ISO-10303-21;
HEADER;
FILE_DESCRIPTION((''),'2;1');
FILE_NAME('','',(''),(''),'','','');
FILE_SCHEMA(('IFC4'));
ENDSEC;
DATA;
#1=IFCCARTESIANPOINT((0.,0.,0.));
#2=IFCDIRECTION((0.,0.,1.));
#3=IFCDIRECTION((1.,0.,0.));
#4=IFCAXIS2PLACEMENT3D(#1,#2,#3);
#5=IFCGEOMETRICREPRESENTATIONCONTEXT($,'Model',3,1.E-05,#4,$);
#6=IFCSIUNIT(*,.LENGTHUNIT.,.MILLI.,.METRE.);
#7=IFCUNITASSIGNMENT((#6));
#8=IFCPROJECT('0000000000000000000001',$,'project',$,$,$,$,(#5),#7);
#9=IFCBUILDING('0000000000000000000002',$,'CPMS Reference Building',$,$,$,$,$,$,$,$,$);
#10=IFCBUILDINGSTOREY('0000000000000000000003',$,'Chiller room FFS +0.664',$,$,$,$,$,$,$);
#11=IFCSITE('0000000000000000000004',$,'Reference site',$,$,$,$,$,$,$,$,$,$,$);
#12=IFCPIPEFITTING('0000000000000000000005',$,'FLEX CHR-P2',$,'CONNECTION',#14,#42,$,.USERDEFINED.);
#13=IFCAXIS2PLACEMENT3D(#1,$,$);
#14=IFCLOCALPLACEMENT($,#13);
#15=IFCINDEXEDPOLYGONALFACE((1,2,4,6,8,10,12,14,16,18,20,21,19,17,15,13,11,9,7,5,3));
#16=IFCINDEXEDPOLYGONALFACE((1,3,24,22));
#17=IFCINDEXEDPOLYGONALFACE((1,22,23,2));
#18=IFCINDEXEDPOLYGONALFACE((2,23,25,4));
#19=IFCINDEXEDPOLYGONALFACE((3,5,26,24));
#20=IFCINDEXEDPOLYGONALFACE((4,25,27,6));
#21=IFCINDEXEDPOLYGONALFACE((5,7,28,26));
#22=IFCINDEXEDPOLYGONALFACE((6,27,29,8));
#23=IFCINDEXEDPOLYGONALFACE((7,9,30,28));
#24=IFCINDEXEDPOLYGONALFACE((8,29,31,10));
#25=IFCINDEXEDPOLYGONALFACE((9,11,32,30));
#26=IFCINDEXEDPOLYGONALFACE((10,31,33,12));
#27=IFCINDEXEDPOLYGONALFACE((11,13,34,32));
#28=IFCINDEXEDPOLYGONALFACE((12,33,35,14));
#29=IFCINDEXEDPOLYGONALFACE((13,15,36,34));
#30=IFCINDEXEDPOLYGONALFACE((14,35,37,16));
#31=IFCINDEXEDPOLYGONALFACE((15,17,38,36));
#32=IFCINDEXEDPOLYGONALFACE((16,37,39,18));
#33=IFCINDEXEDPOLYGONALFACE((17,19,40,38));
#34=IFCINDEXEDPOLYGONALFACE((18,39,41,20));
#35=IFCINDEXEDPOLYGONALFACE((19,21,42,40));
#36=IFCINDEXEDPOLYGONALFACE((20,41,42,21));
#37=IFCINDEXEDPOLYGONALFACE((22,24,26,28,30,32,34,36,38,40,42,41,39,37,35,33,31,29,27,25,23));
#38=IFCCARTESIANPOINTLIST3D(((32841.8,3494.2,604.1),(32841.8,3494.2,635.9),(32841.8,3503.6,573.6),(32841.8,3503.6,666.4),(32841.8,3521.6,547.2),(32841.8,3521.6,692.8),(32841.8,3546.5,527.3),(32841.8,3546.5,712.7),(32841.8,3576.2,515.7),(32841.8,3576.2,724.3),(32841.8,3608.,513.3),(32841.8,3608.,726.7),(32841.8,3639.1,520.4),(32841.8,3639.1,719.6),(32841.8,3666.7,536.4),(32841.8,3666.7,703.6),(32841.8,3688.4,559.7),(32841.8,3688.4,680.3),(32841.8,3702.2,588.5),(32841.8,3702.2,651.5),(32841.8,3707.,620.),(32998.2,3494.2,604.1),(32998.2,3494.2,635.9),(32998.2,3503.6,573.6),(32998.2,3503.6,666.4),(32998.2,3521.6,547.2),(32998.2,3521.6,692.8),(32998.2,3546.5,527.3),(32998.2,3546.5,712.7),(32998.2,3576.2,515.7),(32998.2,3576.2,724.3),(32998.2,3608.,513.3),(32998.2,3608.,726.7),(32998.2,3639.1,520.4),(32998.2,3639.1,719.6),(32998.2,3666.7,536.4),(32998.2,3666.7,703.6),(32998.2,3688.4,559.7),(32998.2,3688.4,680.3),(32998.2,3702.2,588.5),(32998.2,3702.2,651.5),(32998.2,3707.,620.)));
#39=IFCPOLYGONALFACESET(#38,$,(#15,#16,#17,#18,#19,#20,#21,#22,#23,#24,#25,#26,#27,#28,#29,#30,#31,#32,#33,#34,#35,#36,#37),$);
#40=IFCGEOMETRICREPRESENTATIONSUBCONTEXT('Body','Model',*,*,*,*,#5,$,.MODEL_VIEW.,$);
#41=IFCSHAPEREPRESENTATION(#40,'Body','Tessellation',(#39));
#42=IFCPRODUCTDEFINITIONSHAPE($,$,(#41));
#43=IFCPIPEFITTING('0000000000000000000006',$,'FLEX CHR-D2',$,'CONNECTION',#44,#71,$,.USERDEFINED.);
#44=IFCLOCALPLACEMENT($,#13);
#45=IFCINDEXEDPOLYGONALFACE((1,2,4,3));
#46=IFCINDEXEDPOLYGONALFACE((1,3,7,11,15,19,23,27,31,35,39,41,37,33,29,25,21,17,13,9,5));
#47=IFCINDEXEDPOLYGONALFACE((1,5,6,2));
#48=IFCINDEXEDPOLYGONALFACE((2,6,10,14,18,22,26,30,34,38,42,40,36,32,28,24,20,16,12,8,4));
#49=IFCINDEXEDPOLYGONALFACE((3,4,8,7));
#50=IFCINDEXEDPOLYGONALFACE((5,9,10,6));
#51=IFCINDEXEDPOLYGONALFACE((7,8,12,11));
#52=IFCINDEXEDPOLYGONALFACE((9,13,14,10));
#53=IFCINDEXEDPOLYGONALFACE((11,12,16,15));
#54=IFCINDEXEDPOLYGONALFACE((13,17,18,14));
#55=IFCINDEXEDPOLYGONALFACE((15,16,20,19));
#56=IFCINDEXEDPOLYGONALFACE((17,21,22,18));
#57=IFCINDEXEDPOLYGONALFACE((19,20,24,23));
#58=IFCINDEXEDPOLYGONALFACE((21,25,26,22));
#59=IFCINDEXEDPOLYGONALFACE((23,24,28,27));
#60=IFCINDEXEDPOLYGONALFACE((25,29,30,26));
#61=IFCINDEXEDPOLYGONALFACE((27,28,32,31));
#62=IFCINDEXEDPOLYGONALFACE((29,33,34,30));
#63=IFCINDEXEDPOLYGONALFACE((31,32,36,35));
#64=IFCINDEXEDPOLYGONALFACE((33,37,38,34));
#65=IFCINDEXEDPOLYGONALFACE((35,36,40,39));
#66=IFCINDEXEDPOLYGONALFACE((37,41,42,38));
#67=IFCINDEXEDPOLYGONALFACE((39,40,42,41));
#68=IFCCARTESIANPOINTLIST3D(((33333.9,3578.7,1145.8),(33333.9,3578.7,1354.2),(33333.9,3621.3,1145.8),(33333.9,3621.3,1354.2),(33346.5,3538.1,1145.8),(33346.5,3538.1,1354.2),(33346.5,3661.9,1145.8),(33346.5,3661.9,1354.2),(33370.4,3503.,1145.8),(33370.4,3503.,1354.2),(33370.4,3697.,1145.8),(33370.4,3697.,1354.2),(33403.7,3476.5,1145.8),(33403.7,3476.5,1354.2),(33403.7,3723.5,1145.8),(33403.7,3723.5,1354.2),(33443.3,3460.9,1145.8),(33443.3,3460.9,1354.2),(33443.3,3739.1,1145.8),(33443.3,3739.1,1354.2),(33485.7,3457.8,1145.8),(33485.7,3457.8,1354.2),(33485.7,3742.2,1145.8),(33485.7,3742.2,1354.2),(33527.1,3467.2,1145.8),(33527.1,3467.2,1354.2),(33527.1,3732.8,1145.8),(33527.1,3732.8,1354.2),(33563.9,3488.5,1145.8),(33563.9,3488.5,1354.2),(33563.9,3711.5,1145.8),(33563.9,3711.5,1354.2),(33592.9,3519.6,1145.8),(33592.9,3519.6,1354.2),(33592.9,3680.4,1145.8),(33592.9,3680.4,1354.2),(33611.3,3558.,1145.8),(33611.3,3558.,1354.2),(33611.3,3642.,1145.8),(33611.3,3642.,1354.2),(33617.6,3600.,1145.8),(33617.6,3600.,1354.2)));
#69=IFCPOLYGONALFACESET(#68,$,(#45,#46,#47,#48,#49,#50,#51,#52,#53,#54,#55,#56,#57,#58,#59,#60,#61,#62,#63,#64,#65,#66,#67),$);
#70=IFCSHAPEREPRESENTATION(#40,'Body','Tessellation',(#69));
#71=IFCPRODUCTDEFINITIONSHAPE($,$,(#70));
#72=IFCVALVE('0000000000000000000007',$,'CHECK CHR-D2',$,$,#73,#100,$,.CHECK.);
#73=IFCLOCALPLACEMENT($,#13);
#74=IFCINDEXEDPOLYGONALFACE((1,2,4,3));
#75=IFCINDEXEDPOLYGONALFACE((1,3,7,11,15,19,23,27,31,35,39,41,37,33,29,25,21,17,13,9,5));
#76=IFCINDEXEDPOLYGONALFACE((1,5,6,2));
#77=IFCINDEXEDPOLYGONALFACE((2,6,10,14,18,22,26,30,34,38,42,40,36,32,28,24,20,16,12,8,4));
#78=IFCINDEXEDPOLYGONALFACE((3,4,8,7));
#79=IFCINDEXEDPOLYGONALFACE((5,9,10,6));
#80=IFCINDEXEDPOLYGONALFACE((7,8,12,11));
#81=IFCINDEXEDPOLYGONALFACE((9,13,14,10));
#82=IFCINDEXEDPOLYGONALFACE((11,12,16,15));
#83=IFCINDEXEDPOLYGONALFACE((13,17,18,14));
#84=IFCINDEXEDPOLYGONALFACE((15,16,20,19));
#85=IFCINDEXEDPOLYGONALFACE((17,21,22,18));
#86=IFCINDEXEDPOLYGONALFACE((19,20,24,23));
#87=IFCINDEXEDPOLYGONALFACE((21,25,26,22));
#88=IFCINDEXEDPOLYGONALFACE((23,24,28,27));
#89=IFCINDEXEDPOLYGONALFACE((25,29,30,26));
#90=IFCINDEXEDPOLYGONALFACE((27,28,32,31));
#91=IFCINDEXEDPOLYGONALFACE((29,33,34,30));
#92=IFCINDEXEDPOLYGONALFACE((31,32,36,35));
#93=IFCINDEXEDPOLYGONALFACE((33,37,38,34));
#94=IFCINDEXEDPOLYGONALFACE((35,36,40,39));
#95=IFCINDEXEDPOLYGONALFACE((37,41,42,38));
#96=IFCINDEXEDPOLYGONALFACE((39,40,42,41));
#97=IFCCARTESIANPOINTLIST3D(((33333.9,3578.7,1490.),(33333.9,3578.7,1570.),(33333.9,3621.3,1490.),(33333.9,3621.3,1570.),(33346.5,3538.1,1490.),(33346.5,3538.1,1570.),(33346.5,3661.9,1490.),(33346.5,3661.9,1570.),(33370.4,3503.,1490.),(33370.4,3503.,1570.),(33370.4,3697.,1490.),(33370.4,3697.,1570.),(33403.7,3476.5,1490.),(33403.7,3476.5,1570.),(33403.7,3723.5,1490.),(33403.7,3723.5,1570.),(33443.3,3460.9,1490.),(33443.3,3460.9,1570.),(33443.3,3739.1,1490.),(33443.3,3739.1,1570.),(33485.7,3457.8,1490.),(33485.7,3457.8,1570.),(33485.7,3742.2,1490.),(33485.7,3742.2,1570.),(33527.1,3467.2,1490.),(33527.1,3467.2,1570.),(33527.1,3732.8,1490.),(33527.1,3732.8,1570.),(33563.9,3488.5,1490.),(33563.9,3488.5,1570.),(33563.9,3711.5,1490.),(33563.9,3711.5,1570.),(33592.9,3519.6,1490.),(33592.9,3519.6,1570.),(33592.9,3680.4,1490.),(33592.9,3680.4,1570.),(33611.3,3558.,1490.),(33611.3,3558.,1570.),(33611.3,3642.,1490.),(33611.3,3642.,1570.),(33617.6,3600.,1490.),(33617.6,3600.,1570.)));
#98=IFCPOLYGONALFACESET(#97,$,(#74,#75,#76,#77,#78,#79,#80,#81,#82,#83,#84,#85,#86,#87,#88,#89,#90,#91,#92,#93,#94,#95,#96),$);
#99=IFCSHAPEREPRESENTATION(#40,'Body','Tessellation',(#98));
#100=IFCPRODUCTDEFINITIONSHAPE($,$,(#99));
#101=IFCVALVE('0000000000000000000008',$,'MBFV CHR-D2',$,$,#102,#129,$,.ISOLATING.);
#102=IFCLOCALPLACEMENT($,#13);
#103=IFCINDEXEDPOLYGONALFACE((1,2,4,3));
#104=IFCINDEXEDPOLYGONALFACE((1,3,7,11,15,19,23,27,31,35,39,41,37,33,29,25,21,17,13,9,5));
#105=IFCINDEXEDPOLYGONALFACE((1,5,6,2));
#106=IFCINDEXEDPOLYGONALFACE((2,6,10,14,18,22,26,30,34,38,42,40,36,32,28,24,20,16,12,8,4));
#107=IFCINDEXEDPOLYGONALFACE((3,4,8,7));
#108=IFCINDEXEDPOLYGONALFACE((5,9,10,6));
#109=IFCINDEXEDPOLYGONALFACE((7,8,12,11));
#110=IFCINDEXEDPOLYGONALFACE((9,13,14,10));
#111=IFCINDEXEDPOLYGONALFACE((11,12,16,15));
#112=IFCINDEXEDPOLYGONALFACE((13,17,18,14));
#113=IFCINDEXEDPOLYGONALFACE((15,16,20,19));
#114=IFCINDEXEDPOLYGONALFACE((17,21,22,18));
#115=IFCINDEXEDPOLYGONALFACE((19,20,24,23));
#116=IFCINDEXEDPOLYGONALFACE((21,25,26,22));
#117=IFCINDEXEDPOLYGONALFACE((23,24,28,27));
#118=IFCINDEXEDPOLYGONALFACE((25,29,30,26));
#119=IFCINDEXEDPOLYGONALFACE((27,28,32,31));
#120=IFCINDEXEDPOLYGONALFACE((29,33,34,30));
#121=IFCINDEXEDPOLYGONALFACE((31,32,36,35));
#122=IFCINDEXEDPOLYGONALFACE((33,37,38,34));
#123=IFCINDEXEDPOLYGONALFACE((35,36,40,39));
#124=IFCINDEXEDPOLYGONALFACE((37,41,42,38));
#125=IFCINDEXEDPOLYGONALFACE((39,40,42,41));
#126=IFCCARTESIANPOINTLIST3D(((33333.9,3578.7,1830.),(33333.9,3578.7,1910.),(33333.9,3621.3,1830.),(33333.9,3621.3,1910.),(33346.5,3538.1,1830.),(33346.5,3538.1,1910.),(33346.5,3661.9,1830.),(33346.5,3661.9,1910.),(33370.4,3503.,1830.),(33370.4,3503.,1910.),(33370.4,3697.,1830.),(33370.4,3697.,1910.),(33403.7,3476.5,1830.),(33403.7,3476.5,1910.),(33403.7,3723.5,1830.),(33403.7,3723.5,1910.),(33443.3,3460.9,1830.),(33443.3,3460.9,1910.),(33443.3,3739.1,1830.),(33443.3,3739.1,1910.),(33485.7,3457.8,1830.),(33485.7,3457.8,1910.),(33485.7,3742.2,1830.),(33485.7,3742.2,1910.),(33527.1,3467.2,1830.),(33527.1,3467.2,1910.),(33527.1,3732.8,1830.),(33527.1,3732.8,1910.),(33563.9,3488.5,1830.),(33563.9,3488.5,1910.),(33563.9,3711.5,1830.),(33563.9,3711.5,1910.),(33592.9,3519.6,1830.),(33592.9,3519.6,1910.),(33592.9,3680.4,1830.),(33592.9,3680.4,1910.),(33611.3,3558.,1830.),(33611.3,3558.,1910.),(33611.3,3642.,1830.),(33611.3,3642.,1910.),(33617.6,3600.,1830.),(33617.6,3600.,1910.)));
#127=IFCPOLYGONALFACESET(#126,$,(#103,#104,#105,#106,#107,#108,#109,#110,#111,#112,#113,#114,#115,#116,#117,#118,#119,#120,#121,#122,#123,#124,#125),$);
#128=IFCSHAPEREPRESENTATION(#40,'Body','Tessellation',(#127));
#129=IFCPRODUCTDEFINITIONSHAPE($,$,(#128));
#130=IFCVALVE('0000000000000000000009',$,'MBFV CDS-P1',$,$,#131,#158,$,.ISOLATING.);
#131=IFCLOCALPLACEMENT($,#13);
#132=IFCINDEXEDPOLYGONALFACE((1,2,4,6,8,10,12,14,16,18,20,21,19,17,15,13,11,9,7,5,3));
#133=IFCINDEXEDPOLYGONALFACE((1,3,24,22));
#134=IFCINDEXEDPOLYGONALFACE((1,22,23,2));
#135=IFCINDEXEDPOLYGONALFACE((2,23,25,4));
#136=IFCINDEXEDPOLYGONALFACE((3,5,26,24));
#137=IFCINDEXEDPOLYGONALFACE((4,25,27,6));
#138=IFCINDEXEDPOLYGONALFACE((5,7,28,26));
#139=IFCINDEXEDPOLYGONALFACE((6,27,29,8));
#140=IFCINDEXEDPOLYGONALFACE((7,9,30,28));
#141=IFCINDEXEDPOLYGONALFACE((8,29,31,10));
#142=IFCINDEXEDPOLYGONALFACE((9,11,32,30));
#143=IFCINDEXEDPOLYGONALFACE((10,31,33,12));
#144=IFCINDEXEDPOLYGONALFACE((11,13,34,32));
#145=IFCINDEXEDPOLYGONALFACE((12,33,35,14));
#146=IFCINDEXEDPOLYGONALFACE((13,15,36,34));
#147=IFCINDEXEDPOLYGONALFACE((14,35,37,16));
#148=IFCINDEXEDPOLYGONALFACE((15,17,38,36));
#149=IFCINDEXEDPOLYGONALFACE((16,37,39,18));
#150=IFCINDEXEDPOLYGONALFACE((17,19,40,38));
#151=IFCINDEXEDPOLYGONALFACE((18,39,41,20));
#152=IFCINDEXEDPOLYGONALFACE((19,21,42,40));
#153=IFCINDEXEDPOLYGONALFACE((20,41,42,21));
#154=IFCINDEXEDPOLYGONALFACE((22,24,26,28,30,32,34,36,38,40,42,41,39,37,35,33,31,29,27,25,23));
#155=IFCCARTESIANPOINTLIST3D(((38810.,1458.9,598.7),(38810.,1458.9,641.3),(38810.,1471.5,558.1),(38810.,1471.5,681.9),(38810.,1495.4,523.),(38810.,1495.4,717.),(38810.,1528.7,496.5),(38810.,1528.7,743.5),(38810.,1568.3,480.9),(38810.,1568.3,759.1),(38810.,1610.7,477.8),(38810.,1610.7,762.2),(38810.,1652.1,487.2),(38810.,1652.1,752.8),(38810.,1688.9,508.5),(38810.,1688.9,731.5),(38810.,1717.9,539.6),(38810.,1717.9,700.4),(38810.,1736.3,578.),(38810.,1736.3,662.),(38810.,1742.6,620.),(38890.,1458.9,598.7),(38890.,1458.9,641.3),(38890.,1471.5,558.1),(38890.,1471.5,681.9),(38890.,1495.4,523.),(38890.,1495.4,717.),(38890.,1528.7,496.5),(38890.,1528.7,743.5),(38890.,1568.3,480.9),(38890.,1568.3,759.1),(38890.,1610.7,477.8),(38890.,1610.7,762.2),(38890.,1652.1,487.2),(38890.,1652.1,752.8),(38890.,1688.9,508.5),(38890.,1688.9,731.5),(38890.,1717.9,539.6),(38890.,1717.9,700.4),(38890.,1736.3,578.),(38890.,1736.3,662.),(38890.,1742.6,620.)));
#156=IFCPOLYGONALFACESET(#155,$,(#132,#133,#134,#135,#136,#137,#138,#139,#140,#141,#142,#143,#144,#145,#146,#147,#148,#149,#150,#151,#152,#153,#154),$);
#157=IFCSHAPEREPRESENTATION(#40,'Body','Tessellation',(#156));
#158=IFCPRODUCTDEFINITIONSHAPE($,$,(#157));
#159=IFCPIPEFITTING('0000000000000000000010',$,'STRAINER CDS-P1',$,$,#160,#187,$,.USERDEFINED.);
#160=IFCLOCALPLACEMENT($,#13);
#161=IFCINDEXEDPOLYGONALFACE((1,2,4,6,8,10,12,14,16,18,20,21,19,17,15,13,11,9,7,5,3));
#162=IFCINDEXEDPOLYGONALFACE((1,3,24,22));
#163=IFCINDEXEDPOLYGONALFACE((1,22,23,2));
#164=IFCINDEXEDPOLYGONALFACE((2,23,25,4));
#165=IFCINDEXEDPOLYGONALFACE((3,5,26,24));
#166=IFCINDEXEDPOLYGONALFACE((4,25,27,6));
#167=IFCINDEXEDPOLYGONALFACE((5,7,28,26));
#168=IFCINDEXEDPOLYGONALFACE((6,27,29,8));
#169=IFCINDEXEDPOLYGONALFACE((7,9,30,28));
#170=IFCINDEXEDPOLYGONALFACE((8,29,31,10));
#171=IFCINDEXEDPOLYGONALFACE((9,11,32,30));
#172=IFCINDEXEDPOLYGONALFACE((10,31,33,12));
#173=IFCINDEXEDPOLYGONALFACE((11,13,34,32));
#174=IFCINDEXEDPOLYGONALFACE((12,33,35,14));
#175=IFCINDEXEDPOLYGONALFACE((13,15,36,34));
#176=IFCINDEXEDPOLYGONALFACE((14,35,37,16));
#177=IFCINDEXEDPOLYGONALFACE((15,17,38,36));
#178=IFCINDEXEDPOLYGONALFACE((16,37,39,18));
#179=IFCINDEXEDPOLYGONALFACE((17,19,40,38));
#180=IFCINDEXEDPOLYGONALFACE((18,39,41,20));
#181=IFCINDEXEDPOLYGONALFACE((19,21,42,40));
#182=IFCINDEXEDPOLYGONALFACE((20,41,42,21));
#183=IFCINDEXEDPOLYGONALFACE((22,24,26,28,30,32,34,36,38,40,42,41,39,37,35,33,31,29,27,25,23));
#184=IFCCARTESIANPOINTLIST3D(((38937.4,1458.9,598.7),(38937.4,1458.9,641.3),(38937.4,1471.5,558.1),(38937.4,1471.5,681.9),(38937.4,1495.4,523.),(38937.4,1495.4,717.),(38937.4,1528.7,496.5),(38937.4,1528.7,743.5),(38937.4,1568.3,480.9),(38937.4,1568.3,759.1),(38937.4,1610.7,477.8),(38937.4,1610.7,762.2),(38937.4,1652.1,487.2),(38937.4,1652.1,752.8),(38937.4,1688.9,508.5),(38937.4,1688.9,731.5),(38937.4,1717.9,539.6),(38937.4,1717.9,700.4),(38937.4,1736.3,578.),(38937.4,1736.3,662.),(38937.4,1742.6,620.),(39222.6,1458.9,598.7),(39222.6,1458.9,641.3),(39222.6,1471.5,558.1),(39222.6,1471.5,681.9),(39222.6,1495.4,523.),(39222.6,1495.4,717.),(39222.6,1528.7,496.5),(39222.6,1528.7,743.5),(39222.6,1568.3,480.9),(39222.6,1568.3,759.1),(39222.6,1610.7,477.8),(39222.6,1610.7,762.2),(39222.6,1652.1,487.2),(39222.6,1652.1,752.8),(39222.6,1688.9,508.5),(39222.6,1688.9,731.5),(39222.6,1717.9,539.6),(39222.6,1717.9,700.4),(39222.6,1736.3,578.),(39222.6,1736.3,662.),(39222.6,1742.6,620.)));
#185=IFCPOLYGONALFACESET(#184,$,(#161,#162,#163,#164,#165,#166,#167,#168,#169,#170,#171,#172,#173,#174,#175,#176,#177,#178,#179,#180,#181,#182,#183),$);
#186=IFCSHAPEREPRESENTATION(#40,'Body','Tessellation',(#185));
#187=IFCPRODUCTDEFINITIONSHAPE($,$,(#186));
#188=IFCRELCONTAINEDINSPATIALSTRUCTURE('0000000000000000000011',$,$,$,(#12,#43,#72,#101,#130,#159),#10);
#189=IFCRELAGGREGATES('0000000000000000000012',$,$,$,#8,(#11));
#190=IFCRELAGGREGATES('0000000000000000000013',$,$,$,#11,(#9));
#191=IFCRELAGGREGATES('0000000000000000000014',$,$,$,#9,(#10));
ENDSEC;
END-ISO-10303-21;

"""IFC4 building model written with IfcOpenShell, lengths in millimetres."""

from ifc_helpers import new_model, si_unit, frame, origin_with_axes, origin_2d, place, context, subcontext, project, spatial, circle_curve, outline, extrude, element, save


model = new_model("IFC4")

# Units and contexts
model_context = context("Model", 3, precision=1e-05, world=origin_with_axes())
body_context = subcontext(model_context, "Body", "Model", "MODEL_VIEW")
ifc_project = project(units=[si_unit("LENGTHUNIT", "METRE", prefix="MILLI")], contexts=[model_context])

# Site, building, storey
site = spatial("IfcSite", under=ifc_project, Name="Reference site")
building = spatial("IfcBuilding", under=site, Name="CPMS Reference Building")
storey = spatial("IfcBuildingStorey", under=building, Name="Chiller room FFS +0.664")

# Pipe fittings
pipe_fitting_1_placement = place(None, origin_with_axes())
element("IfcPipeFitting", 1, at=pipe_fitting_1_placement, inside=storey, Name="FLEX CHR-P2", ObjectType="CONNECTION", PredefinedType="USERDEFINED", context=body_context, shape_type="SweptSolid", body=[
    extrude(outline(circle_curve(origin_2d(), 107.0)), frame((32841.8, 3600.0, 620.0), z_axis=(1.0, 0.0, 0.0), x_axis=(0.0, 1.0, 0.0)), (0.0, 0.0, 1.0), 156.4),
])
pipe_fitting_2_placement = place(None, origin_with_axes())
element("IfcPipeFitting", 2, at=pipe_fitting_2_placement, inside=storey, Name="FLEX CHR-D2", ObjectType="CONNECTION", PredefinedType="USERDEFINED", context=body_context, shape_type="SweptSolid", body=[
    extrude(outline(circle_curve(origin_2d(), 142.6)), frame((33475.0, 3600.0, 1145.8), z_axis=(0.0, 0.0, 1.0), x_axis=(1.0, 0.0, 0.0)), (0.0, 0.0, 1.0), 208.5),
])

# Valves
valve_1_placement = place(None, origin_with_axes())
element("IfcValve", 3, at=valve_1_placement, inside=storey, Name="CHECK CHR-D2", PredefinedType="CHECK", context=body_context, shape_type="SweptSolid", body=[
    extrude(outline(circle_curve(origin_2d(), 142.6)), frame((33475.0, 3600.0, 1490.0), z_axis=(0.0, 0.0, 1.0), x_axis=(1.0, 0.0, 0.0)), (0.0, 0.0, 1.0), 80.0),
])
valve_2_placement = place(None, origin_with_axes())
element("IfcValve", 4, at=valve_2_placement, inside=storey, Name="MBFV CHR-D2", PredefinedType="ISOLATING", context=body_context, shape_type="SweptSolid", body=[
    extrude(outline(circle_curve(origin_2d(), 142.6)), frame((33475.0, 3600.0, 1830.0), z_axis=(0.0, 0.0, 1.0), x_axis=(1.0, 0.0, 0.0)), (0.0, 0.0, 1.0), 80.0),
])
valve_3_placement = place(None, origin_with_axes())
element("IfcValve", 5, at=valve_3_placement, inside=storey, Name="MBFV CDS-P1", PredefinedType="ISOLATING", context=body_context, shape_type="SweptSolid", body=[
    extrude(outline(circle_curve(origin_2d(), 142.6)), frame((38810.0, 1600.0, 620.0), z_axis=(1.0, 0.0, 0.0), x_axis=(0.0, 1.0, 0.0)), (0.0, 0.0, 1.0), 80.0),
])

# Pipe fitting
pipe_fitting_3_placement = place(None, origin_with_axes())
element("IfcPipeFitting", 6, at=pipe_fitting_3_placement, inside=storey, Name="STRAINER CDS-P1", PredefinedType="USERDEFINED", context=body_context, shape_type="SweptSolid", body=[
    extrude(outline(circle_curve(origin_2d(), 142.6)), frame((38937.4, 1600.0, 620.0), z_axis=(1.0, 0.0, 0.0), x_axis=(0.0, 1.0, 0.0)), (0.0, 0.0, 1.0), 285.3),
])

save(model, "model.ifc")
